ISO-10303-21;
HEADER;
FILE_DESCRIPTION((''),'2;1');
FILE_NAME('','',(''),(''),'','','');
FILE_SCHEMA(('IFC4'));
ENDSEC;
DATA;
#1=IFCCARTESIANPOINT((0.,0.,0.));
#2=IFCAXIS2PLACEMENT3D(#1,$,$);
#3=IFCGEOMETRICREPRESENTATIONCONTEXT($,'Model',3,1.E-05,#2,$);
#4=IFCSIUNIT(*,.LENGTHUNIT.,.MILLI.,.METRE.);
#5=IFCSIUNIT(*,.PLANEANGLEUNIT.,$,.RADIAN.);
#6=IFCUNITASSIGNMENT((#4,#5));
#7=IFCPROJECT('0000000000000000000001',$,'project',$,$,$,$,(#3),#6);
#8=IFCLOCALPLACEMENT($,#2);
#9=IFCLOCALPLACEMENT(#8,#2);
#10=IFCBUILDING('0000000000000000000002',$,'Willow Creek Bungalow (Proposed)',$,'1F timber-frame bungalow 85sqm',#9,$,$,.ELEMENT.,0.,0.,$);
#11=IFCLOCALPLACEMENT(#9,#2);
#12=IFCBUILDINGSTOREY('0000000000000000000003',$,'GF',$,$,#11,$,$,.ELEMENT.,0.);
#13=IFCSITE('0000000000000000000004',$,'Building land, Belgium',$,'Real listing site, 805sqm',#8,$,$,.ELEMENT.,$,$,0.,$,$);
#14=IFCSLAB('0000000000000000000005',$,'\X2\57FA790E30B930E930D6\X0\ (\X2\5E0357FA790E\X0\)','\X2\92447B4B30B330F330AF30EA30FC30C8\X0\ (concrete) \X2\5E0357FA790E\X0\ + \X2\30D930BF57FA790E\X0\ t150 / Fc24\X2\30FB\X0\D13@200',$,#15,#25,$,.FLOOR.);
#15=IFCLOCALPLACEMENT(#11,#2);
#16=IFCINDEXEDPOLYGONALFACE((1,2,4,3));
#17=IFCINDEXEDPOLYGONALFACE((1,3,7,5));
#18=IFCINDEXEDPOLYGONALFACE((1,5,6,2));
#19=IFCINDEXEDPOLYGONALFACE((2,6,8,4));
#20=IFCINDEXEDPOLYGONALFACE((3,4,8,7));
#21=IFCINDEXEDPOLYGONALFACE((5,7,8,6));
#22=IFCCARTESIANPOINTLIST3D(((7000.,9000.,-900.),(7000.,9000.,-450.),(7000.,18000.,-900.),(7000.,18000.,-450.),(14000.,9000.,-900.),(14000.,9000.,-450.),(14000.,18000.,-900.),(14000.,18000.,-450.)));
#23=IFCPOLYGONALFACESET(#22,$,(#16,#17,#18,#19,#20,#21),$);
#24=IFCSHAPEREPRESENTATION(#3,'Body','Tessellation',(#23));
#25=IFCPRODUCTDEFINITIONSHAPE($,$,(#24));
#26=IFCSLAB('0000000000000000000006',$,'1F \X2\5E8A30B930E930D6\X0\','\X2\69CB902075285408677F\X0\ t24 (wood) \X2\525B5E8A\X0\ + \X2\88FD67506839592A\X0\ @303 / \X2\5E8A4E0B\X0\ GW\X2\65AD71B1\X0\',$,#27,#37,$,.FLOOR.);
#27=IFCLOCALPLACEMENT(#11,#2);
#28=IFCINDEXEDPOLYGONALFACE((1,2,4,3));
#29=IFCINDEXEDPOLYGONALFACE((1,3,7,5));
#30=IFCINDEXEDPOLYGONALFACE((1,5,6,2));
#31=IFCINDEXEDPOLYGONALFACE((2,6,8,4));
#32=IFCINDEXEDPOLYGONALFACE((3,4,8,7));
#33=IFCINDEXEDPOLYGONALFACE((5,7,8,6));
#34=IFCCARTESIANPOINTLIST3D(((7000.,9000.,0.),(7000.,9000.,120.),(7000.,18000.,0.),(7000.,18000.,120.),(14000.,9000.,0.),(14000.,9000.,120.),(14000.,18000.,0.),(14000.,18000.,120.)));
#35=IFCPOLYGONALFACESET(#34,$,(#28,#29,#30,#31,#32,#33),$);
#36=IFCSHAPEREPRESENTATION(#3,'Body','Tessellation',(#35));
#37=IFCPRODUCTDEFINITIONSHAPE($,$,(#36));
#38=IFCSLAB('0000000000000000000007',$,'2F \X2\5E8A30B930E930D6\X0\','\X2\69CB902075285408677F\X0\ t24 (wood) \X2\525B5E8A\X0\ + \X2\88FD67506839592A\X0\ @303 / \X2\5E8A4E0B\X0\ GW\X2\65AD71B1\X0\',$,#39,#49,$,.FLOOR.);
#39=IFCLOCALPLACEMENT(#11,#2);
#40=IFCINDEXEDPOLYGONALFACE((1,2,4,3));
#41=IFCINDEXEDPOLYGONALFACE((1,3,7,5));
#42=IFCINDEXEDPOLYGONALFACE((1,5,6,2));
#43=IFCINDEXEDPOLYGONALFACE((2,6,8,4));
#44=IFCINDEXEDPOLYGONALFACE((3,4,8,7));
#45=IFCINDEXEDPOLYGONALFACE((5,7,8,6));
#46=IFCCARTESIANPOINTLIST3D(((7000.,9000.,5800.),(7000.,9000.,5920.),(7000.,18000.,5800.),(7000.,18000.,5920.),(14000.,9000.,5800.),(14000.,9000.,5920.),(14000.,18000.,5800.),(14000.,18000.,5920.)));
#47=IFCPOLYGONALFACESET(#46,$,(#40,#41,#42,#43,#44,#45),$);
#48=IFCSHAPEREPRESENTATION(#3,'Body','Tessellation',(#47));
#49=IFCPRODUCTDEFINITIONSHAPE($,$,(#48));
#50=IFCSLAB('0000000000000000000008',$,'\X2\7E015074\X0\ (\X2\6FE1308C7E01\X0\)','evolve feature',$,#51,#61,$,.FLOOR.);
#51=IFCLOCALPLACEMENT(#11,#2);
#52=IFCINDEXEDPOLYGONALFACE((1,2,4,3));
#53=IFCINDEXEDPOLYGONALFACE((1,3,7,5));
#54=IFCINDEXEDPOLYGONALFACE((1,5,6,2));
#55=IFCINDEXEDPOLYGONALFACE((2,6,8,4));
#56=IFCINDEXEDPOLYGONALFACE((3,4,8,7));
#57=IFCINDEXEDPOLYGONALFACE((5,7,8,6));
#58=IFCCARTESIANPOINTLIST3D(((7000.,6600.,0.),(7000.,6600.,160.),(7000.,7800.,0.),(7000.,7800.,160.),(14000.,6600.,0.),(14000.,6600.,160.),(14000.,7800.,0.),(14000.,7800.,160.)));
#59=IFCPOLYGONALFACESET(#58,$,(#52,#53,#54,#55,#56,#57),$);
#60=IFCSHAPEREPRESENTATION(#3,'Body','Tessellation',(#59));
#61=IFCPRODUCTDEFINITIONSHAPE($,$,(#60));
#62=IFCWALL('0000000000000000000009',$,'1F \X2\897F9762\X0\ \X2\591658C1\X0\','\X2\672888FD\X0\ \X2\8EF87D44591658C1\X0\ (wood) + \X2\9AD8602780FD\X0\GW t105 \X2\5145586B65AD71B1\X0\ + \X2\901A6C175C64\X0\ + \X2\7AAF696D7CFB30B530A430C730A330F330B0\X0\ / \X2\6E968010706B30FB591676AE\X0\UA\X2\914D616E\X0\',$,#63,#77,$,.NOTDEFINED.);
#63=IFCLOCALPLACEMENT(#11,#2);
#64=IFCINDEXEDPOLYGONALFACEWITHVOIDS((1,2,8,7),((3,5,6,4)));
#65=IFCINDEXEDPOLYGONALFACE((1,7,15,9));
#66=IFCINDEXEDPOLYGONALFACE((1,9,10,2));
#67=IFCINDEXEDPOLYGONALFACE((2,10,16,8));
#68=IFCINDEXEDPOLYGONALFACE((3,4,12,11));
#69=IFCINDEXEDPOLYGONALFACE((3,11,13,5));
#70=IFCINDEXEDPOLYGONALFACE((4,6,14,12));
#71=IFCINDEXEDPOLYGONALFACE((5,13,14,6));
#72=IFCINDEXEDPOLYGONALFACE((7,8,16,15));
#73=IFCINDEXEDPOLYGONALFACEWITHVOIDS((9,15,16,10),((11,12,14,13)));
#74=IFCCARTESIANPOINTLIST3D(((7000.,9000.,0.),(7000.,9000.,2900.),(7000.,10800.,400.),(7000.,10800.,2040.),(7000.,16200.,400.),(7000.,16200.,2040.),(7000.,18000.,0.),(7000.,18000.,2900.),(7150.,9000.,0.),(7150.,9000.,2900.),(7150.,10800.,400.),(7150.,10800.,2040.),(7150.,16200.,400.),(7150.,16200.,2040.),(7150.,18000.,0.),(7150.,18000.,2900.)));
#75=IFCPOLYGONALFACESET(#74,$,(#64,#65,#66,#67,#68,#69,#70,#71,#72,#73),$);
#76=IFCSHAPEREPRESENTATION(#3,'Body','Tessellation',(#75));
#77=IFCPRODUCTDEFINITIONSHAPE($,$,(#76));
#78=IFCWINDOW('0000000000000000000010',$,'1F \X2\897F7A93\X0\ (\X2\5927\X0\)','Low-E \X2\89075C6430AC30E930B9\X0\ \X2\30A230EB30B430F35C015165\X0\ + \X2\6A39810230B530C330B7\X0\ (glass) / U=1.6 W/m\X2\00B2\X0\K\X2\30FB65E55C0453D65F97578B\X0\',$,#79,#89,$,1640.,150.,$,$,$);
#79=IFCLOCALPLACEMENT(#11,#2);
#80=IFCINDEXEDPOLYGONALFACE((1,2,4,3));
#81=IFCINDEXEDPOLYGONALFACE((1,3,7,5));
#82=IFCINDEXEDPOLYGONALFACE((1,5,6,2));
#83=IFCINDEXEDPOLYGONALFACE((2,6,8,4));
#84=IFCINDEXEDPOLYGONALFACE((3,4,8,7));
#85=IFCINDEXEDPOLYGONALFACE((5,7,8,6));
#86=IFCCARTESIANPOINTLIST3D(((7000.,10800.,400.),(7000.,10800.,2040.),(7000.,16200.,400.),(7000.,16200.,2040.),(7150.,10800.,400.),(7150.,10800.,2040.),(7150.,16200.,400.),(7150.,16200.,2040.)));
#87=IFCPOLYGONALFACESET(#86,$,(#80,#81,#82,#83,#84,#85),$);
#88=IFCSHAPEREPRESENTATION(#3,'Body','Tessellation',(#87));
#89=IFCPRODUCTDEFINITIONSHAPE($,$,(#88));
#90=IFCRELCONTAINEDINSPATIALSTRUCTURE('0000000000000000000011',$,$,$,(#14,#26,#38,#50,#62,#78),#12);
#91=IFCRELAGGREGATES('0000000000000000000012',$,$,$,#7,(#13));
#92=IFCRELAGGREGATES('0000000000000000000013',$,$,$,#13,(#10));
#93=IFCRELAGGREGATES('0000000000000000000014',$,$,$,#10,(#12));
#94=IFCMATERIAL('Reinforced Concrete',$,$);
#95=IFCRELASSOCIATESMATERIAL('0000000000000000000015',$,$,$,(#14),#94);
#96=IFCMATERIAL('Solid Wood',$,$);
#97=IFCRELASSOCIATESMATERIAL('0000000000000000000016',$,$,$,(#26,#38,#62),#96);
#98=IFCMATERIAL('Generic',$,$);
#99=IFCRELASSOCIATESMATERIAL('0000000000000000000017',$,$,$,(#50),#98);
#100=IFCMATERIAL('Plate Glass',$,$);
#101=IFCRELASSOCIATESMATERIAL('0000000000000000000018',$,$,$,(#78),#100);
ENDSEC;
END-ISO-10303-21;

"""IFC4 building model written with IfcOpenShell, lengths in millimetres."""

from ifc_helpers import new_model, si_unit, frame, frame_2d, origin, place, context, project, spatial, rectangle, extrude, material, element, fill, save


model = new_model("IFC4")

# Units and contexts
model_context = context("Model", 3, precision=1e-05, world=origin())
ifc_project = project(units=[si_unit("LENGTHUNIT", "METRE", prefix="MILLI"), si_unit("PLANEANGLEUNIT", "RADIAN")], contexts=[model_context])

# Site, building, storey
site_placement = place(None, origin())
site = spatial("IfcSite", under=ifc_project, at=site_placement, Name="Building land, Belgium", ObjectType="Real listing site, 805sqm", CompositionType="ELEMENT", RefElevation=0.0)
building_placement = place(site_placement, origin())
building = spatial("IfcBuilding", under=site, at=building_placement, Name="Willow Creek Bungalow (Proposed)", ObjectType="1F timber-frame bungalow 85sqm", CompositionType="ELEMENT", ElevationOfRefHeight=0.0, ElevationOfTerrain=0.0)
storey_placement = place(building_placement, origin())
storey = spatial("IfcBuildingStorey", under=building, at=storey_placement, Name="GF", CompositionType="ELEMENT", Elevation=0.0)

# Slabs
ifc_material_1 = material(Name="Reinforced Concrete")
slab_1_placement = place(storey_placement, frame((3500.0, 4500.0, -450.0)))
element("IfcSlab", 1, at=slab_1_placement, inside=storey, material=ifc_material_1, Name="基礎スラブ (布基礎)", Description="鉄筋コンクリート (concrete) 布基礎 + ベタ基礎 t150 / Fc24・D13@200", PredefinedType="FLOOR", context=model_context, shape_type="SweptSolid", body=[
    extrude(rectangle(XDim=7000.0, YDim=9000.0, at=frame_2d((3500.0, 4500.0))), frame((3500.0, 4500.0, -450.0)), (0.0, 0.0, 1.0), 450.0),
])
ifc_material_2 = material(Name="Solid Wood")
slab_2_placement = place(storey_placement, frame((3500.0, 4500.0, 0.0)))
element("IfcSlab", 2, at=slab_2_placement, inside=storey, material=ifc_material_2, Name="1F 床スラブ", Description="構造用合板 t24 (wood) 剛床 + 製材根太 @303 / 床下 GW断熱", PredefinedType="FLOOR", context=model_context, shape_type="SweptSolid", body=[
    extrude(rectangle(XDim=7000.0, YDim=9000.0, at=frame_2d((3500.0, 4500.0))), frame((3500.0, 4500.0, 0.0)), (0.0, 0.0, 1.0), 120.0),
])
slab_3_placement = place(storey_placement, frame((3500.0, 4500.0, 2900.0)))
element("IfcSlab", 3, at=slab_3_placement, inside=storey, material=ifc_material_2, Name="2F 床スラブ", Description="構造用合板 t24 (wood) 剛床 + 製材根太 @303 / 床下 GW断熱", PredefinedType="FLOOR", context=model_context, shape_type="SweptSolid", body=[
    extrude(rectangle(XDim=7000.0, YDim=9000.0, at=frame_2d((3500.0, 4500.0))), frame((3500.0, 4500.0, 2900.0)), (0.0, 0.0, 1.0), 120.0),
])
ifc_material_3 = material(Name="Generic")
slab_4_placement = place(storey_placement, frame((3500.0, 3300.0, 0.0)))
element("IfcSlab", 4, at=slab_4_placement, inside=storey, material=ifc_material_3, Name="縁側 (濡れ縁)", Description="evolve feature", PredefinedType="FLOOR", context=model_context, shape_type="SweptSolid", body=[
    extrude(rectangle(XDim=7000.0, YDim=1200.0, at=frame_2d((3500.0, 600.0))), frame((3500.0, 3300.0, 0.0)), (0.0, 0.0, 1.0), 160.0),
])

# Shared definitions
ifc_material_4 = material(Name="Plate Glass")

# Wall, opening, window
wall_1_placement = place(storey_placement, frame((3500.0, 4500.0, 0.0)))
wall_1 = element("IfcWall", 5, at=wall_1_placement, inside=storey, material=ifc_material_2, Name="1F 西面 外壁", Description="木製 軸組外壁 (wood) + 高性能GW t105 充填断熱 + 通気層 + 窯業系サイディング / 準耐火・外皮UA配慮", PredefinedType="NOTDEFINED", context=model_context, shape_type="SweptSolid", body=[
    extrude(rectangle(XDim=150.0, YDim=9000.0, at=frame_2d((75.0, 4500.0))), frame((3500.0, 4500.0, 0.0)), (0.0, 0.0, 1.0), 2900.0),
])
opening_1_placement = place(storey_placement, frame((3500.0, 5400.0, 200.0)))
opening_1 = element("IfcOpeningElement", 6, at=opening_1_placement, cuts=wall_1, PredefinedType="NOTDEFINED", context=model_context, shape_type="SweptSolid", body=[
    extrude(rectangle(XDim=150.0, YDim=5400.0, at=frame_2d((75.0, 2700.0))), frame((3500.0, 5400.0, 200.0)), (0.0, 0.0, 1.0), 1640.0),
])
window_1_placement = place(storey_placement, frame((3500.0, 5400.0, 200.0)))
window_1 = element("IfcWindow", 7, at=window_1_placement, inside=storey, material=ifc_material_4, Name="1F 西窓 (大)", Description="Low-E 複層ガラス アルゴン封入 + 樹脂サッシ (glass) / U=1.6 W/m²K・日射取得型", OverallHeight=1640.0, OverallWidth=150.0, context=model_context, shape_type="SweptSolid", body=[
    extrude(rectangle(XDim=150.0, YDim=5400.0, at=frame_2d((75.0, 2700.0))), frame((3500.0, 5400.0, 200.0)), (0.0, 0.0, 1.0), 1640.0),
])
fill(opening_1, window_1)

save(model, "model.ifc")
